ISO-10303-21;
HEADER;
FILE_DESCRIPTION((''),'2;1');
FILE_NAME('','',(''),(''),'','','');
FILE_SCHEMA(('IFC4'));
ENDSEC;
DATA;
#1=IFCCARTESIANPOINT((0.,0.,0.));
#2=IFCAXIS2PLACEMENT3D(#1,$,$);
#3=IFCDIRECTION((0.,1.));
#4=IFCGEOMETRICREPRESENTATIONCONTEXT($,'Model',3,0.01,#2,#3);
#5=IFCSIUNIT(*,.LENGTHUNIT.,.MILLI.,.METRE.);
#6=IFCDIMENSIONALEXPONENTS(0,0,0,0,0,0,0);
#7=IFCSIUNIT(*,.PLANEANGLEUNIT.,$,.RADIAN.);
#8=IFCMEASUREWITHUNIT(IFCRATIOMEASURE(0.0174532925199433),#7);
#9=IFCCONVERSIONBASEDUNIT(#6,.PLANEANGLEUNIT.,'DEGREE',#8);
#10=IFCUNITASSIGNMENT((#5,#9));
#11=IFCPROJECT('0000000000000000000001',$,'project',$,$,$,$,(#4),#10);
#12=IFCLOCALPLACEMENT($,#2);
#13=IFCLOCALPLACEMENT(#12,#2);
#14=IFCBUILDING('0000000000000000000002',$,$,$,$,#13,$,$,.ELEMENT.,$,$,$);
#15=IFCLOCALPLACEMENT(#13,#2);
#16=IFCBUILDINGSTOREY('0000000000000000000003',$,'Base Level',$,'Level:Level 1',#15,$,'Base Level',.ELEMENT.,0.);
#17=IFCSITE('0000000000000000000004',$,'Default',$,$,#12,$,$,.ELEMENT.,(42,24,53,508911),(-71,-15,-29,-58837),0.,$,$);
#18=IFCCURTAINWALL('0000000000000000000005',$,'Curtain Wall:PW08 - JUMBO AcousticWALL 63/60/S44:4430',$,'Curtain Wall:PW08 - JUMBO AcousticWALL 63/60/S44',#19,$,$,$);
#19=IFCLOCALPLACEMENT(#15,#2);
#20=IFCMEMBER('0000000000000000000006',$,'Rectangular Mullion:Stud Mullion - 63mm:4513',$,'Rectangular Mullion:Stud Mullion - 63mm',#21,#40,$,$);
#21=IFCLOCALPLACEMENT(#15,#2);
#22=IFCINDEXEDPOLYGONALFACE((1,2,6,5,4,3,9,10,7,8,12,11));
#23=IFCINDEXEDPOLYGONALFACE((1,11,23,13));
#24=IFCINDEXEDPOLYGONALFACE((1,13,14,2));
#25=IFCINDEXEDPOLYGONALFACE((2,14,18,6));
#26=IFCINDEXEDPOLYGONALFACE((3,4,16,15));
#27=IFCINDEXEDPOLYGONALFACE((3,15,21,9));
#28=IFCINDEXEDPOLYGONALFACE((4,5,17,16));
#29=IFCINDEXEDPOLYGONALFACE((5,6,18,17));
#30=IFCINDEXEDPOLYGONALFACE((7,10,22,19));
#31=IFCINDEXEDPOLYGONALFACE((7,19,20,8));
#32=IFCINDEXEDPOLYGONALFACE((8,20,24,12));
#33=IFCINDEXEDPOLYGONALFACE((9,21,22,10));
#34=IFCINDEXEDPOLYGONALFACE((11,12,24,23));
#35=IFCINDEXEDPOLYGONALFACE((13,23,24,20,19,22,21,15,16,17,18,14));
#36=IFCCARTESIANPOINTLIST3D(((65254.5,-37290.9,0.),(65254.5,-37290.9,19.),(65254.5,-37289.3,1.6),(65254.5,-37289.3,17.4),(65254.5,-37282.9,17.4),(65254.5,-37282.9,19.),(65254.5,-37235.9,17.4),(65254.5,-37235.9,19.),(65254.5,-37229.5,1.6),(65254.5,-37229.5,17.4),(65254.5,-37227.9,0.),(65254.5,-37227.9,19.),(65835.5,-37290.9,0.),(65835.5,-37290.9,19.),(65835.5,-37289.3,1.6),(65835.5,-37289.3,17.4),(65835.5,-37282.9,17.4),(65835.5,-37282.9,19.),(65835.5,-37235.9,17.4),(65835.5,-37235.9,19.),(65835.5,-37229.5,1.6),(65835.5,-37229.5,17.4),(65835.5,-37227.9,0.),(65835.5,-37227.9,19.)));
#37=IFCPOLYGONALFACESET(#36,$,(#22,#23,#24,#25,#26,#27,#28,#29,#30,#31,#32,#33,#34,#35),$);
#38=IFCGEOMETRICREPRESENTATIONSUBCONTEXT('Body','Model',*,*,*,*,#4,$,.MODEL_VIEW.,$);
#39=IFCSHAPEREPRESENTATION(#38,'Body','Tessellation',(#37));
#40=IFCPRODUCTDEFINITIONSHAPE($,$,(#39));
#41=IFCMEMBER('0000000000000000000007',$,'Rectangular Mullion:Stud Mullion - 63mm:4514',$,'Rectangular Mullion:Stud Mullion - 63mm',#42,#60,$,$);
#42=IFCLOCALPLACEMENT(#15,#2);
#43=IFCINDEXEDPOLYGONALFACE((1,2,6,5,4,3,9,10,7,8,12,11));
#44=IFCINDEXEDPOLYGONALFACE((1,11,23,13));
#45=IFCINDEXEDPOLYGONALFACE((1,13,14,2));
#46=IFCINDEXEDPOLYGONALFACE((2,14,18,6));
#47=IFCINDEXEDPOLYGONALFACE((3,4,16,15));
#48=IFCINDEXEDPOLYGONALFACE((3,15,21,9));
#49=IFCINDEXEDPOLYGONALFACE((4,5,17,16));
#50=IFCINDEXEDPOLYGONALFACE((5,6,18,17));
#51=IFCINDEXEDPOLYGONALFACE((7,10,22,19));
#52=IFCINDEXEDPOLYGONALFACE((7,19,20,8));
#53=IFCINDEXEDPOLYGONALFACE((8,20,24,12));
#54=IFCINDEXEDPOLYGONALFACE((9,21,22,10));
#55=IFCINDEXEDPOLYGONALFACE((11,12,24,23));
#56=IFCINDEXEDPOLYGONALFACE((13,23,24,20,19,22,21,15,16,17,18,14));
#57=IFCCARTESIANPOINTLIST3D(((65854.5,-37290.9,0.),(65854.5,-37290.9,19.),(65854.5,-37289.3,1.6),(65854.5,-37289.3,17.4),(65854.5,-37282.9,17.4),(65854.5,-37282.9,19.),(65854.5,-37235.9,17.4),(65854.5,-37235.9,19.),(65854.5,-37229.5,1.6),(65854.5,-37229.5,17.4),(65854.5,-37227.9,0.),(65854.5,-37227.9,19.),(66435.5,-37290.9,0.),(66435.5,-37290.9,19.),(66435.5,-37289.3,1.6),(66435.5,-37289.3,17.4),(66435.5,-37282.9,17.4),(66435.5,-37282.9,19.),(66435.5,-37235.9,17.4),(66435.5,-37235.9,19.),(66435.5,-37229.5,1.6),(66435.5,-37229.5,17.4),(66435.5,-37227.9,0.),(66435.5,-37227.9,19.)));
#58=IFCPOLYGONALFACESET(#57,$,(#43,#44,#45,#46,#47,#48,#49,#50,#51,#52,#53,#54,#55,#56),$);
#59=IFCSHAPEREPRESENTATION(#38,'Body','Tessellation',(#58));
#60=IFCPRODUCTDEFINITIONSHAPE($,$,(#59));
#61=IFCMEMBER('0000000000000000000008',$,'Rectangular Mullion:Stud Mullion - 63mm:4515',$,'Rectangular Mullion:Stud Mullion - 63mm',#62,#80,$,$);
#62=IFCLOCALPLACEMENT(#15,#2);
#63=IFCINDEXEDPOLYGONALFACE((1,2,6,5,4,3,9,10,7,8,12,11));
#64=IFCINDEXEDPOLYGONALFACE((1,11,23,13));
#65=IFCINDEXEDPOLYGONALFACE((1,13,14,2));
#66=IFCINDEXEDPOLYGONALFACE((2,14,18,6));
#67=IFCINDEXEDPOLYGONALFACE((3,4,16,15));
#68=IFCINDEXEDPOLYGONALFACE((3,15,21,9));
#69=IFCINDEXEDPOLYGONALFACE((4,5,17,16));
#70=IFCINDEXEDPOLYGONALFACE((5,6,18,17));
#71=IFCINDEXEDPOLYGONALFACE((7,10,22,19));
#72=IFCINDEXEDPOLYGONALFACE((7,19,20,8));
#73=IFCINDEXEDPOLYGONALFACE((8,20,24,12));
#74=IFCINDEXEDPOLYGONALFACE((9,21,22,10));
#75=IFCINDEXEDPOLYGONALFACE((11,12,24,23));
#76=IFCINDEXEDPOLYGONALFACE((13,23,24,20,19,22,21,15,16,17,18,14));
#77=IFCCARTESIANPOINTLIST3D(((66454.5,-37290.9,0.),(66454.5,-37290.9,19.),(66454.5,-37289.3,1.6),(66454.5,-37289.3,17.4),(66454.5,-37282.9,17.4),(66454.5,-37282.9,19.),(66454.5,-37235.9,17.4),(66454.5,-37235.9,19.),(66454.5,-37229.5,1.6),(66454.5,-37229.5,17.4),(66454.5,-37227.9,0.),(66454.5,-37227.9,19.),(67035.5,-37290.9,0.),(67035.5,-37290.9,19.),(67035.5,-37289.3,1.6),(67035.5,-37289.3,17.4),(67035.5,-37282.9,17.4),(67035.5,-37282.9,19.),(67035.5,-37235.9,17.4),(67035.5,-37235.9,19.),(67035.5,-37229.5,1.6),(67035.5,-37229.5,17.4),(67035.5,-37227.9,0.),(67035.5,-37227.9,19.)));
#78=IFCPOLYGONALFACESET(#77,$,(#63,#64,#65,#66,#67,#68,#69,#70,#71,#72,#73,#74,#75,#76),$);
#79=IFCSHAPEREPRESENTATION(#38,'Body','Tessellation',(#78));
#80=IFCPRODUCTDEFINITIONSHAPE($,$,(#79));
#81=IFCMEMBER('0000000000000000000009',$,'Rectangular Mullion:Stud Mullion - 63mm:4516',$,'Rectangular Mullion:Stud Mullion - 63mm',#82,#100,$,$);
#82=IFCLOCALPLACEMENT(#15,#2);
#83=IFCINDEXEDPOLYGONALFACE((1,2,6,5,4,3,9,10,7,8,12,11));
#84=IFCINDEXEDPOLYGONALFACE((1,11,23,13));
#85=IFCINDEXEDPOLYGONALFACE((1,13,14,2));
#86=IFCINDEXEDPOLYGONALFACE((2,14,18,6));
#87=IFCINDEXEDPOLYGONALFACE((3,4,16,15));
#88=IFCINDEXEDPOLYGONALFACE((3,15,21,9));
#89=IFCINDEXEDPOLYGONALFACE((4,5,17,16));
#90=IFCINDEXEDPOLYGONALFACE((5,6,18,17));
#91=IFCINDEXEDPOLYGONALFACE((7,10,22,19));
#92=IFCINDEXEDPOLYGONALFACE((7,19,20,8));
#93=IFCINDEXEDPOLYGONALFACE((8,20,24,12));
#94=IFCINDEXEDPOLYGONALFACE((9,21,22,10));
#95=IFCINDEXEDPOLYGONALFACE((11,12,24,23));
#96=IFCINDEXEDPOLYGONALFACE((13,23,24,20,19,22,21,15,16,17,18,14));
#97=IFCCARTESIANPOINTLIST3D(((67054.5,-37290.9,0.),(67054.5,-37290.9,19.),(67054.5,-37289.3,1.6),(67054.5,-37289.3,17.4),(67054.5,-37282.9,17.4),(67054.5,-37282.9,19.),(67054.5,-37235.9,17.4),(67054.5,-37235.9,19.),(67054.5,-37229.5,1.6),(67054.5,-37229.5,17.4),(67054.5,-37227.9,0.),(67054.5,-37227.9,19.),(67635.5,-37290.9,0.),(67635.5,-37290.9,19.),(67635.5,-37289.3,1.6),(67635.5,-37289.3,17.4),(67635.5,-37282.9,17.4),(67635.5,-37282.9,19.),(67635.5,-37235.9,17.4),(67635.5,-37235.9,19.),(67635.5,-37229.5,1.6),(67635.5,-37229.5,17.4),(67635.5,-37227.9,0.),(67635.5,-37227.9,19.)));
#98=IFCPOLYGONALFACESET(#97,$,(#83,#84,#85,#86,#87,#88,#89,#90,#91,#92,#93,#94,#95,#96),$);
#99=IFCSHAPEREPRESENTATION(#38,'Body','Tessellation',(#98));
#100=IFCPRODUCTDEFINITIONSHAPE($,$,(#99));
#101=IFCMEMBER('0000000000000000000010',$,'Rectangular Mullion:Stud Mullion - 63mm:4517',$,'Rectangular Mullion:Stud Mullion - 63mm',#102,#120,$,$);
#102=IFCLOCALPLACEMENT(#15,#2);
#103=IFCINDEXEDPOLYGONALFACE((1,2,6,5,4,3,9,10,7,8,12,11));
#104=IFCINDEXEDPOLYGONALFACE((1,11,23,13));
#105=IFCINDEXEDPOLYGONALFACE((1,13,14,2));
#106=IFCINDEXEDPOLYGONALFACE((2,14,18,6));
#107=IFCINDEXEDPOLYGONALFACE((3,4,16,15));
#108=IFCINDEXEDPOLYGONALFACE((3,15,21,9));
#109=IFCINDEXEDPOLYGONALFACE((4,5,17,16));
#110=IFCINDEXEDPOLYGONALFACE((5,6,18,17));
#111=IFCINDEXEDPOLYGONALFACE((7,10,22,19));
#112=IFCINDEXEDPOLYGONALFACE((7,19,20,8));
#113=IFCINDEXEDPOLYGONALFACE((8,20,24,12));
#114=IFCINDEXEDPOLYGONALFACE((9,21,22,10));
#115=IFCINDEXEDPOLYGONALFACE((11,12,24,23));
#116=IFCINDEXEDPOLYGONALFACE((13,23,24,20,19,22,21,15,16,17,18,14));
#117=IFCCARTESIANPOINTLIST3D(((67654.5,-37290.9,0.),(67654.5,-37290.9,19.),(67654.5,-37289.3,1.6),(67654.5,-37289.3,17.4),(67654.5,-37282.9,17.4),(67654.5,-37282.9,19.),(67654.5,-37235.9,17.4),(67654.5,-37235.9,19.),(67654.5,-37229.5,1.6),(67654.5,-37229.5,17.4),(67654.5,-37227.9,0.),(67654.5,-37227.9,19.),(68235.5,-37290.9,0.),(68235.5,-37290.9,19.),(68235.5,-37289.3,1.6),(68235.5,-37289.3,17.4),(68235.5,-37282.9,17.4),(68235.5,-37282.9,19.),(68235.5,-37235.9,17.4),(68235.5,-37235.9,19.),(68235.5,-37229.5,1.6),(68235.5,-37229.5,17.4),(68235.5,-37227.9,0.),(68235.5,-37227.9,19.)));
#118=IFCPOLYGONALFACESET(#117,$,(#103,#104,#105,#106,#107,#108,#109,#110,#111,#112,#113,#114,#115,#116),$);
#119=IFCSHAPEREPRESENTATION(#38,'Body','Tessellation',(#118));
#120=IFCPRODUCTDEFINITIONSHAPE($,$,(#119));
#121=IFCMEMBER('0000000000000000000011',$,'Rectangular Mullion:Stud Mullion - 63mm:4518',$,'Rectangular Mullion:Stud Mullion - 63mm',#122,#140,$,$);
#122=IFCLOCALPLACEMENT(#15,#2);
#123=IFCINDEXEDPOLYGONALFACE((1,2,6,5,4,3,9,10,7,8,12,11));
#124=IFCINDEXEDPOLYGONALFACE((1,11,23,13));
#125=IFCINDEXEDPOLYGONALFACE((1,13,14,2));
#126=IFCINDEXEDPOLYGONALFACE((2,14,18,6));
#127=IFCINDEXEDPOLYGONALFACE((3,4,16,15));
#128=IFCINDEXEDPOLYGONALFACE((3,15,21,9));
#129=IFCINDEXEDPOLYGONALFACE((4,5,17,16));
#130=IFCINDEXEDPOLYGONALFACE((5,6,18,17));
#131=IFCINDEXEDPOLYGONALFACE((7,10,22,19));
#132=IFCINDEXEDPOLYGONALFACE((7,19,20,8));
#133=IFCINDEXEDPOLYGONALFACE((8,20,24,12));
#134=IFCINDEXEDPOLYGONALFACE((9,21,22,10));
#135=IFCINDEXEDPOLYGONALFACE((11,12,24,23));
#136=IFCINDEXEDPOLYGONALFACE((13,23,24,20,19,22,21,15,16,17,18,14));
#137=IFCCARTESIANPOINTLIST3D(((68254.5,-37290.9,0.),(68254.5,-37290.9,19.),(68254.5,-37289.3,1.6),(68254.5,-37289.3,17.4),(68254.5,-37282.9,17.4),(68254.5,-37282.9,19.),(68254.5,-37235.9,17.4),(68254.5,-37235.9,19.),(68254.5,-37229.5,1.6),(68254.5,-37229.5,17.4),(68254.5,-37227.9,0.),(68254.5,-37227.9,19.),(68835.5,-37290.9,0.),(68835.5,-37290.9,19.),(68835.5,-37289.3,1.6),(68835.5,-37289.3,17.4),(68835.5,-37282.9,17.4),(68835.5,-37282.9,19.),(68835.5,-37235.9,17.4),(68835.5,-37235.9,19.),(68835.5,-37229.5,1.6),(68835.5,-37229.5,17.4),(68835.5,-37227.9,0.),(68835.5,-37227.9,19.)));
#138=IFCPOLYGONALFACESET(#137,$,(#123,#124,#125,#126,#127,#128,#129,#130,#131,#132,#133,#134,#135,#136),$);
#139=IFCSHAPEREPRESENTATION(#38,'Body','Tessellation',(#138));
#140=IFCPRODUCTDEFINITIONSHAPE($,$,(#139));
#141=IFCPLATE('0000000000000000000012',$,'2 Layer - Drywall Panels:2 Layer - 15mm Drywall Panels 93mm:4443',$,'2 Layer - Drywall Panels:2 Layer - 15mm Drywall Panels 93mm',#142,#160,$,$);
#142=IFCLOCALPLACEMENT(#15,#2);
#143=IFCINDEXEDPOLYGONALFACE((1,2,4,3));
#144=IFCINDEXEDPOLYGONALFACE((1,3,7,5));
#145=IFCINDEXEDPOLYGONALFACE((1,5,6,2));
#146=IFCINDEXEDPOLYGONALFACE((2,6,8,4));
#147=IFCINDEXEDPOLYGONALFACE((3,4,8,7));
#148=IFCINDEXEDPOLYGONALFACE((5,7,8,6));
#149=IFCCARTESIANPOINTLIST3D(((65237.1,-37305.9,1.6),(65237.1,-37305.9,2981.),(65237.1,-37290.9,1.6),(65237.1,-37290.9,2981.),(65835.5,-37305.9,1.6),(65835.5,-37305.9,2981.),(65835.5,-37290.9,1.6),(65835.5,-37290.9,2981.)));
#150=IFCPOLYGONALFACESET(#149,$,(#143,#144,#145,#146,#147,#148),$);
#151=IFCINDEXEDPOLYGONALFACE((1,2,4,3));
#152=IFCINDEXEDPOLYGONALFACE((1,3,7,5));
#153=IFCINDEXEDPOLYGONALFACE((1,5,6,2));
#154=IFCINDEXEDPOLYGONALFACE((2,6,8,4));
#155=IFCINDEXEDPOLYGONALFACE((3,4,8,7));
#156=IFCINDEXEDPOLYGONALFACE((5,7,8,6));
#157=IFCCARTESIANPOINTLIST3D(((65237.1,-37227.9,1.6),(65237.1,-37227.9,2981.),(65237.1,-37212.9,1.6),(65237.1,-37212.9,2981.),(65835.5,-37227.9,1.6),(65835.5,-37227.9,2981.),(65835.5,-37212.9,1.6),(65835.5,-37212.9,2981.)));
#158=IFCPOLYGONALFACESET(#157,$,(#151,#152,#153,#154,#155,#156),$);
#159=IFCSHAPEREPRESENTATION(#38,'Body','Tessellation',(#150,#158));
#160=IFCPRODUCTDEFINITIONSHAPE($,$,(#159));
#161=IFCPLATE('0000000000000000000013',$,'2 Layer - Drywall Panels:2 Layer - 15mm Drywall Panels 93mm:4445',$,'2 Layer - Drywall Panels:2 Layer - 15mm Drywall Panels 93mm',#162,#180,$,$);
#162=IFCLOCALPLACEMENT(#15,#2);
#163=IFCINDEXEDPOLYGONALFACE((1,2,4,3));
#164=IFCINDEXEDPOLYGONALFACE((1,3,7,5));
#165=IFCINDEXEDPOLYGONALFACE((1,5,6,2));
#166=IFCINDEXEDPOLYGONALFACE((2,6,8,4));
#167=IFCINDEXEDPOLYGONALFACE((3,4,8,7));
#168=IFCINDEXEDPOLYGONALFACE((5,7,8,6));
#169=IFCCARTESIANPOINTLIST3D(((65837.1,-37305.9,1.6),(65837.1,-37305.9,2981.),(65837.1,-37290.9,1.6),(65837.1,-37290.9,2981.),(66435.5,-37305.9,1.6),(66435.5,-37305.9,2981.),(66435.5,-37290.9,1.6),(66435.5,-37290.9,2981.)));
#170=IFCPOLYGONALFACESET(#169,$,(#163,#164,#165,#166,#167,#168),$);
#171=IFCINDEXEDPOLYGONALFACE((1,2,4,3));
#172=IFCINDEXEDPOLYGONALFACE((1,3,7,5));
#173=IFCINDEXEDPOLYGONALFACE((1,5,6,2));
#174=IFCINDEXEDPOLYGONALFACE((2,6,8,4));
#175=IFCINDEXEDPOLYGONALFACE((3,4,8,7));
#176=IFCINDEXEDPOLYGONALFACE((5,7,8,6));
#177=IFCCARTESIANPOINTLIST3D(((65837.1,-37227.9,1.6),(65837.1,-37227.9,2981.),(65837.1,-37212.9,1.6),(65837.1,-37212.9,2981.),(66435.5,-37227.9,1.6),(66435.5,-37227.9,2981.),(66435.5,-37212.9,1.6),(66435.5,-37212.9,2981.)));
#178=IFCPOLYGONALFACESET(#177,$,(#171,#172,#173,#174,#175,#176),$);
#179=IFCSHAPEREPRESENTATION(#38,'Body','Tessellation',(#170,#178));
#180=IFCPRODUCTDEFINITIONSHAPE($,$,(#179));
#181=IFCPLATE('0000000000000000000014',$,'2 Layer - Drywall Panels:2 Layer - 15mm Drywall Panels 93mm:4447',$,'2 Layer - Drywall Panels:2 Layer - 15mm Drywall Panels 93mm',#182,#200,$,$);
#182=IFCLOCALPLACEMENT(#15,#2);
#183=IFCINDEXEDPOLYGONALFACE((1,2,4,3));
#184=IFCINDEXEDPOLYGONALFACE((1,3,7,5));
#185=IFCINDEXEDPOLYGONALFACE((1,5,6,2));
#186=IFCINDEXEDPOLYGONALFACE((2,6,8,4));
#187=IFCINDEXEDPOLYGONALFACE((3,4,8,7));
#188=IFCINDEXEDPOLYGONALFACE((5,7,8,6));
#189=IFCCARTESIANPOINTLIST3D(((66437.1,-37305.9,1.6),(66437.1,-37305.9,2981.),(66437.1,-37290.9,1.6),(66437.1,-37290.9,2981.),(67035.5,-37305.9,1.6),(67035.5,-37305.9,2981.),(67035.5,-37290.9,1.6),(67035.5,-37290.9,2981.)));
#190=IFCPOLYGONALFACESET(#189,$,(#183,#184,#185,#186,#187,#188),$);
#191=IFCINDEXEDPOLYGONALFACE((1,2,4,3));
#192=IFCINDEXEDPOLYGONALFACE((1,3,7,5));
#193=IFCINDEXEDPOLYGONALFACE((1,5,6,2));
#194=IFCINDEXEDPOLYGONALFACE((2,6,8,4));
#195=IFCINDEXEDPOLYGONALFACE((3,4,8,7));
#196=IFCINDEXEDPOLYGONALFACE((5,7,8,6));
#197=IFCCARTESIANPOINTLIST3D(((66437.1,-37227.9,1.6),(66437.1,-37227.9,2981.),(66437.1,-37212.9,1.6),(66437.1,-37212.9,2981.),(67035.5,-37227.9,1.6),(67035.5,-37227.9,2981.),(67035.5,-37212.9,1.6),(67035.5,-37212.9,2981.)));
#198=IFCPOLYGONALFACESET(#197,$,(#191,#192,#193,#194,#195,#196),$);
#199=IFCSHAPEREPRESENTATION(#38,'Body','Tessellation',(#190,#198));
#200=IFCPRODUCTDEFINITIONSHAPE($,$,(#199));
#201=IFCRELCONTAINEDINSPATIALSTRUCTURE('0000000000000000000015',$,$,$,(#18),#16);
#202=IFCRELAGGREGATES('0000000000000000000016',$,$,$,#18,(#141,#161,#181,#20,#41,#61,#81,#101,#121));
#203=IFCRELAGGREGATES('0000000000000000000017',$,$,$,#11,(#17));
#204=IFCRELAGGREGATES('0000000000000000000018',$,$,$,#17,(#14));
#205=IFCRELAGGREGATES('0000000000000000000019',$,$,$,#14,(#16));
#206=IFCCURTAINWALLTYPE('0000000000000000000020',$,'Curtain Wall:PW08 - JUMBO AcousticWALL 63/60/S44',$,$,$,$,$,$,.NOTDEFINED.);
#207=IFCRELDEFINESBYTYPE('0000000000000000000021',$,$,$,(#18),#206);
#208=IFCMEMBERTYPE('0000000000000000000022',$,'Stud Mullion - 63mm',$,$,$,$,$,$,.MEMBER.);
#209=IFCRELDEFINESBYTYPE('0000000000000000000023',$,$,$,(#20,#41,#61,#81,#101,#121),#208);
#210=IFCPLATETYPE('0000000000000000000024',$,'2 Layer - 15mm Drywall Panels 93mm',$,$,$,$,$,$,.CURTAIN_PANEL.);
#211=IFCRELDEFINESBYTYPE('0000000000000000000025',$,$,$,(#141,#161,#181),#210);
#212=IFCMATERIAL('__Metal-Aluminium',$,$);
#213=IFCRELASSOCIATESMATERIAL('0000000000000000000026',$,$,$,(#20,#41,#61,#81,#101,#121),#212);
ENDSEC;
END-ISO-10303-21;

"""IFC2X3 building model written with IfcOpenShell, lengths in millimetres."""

from ifc_helpers import new_model, entity, si_unit, converted_unit, direction, frame, frame_2d, origin, place, context, subcontext, project, spatial, polyline, rectangle, outline, extrude, source, transform, mapped, material, type_object, type_shapes, element, aggregate, save


model = new_model("IFC2X3")

# Units and contexts
model_context = context("Model", 3, precision=0.01, world=origin(), true_north=direction((0.0, 1.0)))
body_context = subcontext(model_context, "Body", "Model", "MODEL_VIEW")
ifc_project = project(units=[si_unit("LENGTHUNIT", "METRE", prefix="MILLI"), converted_unit("PLANEANGLEUNIT", "DEGREE", entity("IfcRatioMeasure", 0.0174532925199433), si_unit("PLANEANGLEUNIT", "RADIAN"), dimensions=[0, 0, 0, 0, 0, 0, 0])], contexts=[model_context])

# Site, building, storey
site_placement = place(None, origin())
site = spatial("IfcSite", under=ifc_project, at=site_placement, Name="Default", CompositionType="ELEMENT", RefLatitude=(42, 24, 53, 508911), RefLongitude=(-71, -15, -29, -58837), RefElevation=0.0)
building_placement = place(site_placement, origin())
building = spatial("IfcBuilding", under=site, at=building_placement, CompositionType="ELEMENT")
storey_placement = place(building_placement, origin())
storey = spatial("IfcBuildingStorey", under=building, at=storey_placement, Name="Base Level", ObjectType="Level:Level 1", LongName="Base Level", CompositionType="ELEMENT", Elevation=0.0)

# Curtain wall, members, plates
curtain_wall_type = type_object("IfcCurtainWallType", Name="Curtain Wall:PW08 - JUMBO AcousticWALL 63/60/S44", PredefinedType="NOTDEFINED")
curtain_wall_placement = place(building_placement, origin())
curtain_wall = element("IfcCurtainWall", 1, at=curtain_wall_placement, inside=storey, type_object=curtain_wall_type, Name="Curtain Wall:PW08 - JUMBO AcousticWALL 63/60/S44:4430", ObjectType="Curtain Wall:PW08 - JUMBO AcousticWALL 63/60/S44")
ifc_material = material(Name="__Metal-Aluminium")
member_type_1 = type_object("IfcMemberType", Name="Stud Mullion - 63mm", PredefinedType="MEMBER")
shared_shape_1 = source(origin(), body_context, "Body", "SweptSolid", [
    extrude(outline(polyline([(23.5, -6.6), (31.5, -6.6), (31.5, 12.4), (-31.5, 12.4), (-31.5, -6.6), (-23.5, -6.6), (-23.5, -5.0), (-29.9, -5.0), (-29.9, 10.8), (29.9, 10.8), (29.9, -5.0), (23.5, -5.0), (23.5, -6.6)])), frame((-12.4, 0.0, -581.0), z_axis=(0.0, 0.0, 1.0), x_axis=(0.0, -1.0, 0.0)), (0.0, 0.0, 1.0), 581.0),
])
type_shapes(member_type_1, [shared_shape_1])
member_1_placement = place(building_placement, frame((65254.5, -37259.4, 0.0), z_axis=(-1.0, 0.0, 0.0), x_axis=(0.0, 0.0, -1.0)))
member_1 = element("IfcMember", 2, at=member_1_placement, type_object=member_type_1, material=ifc_material, Name="Rectangular Mullion:Stud Mullion - 63mm:4513", ObjectType="Rectangular Mullion:Stud Mullion - 63mm", context=body_context, shape_type="MappedRepresentation", body=[
    mapped(shared_shape_1, transform((0.0, 0.0, 0.0), scale=1.0)),
])
member_2_placement = place(building_placement, frame((65854.5, -37259.4, 0.0), z_axis=(-1.0, 0.0, 0.0), x_axis=(0.0, 0.0, -1.0)))
member_2 = element("IfcMember", 3, at=member_2_placement, type_object=member_type_1, material=ifc_material, Name="Rectangular Mullion:Stud Mullion - 63mm:4514", ObjectType="Rectangular Mullion:Stud Mullion - 63mm", context=body_context, shape_type="MappedRepresentation", body=[
    mapped(shared_shape_1, transform((0.0, 0.0, 0.0), scale=1.0)),
])
member_3_placement = place(building_placement, frame((66454.5, -37259.4, 0.0), z_axis=(-1.0, 0.0, 0.0), x_axis=(0.0, 0.0, -1.0)))
member_3 = element("IfcMember", 4, at=member_3_placement, type_object=member_type_1, material=ifc_material, Name="Rectangular Mullion:Stud Mullion - 63mm:4515", ObjectType="Rectangular Mullion:Stud Mullion - 63mm", context=body_context, shape_type="MappedRepresentation", body=[
    mapped(shared_shape_1, transform((0.0, 0.0, 0.0), scale=1.0)),
])
member_4_placement = place(building_placement, frame((67054.5, -37259.4, 0.0), z_axis=(-1.0, 0.0, 0.0), x_axis=(0.0, 0.0, -1.0)))
member_4 = element("IfcMember", 5, at=member_4_placement, type_object=member_type_1, material=ifc_material, Name="Rectangular Mullion:Stud Mullion - 63mm:4516", ObjectType="Rectangular Mullion:Stud Mullion - 63mm", context=body_context, shape_type="MappedRepresentation", body=[
    mapped(shared_shape_1, transform((0.0, 0.0, 0.0), scale=1.0)),
])
member_5_placement = place(building_placement, frame((67654.5, -37259.4, 0.0), z_axis=(-1.0, 0.0, 0.0), x_axis=(0.0, 0.0, -1.0)))
member_5 = element("IfcMember", 6, at=member_5_placement, type_object=member_type_1, material=ifc_material, Name="Rectangular Mullion:Stud Mullion - 63mm:4517", ObjectType="Rectangular Mullion:Stud Mullion - 63mm", context=body_context, shape_type="MappedRepresentation", body=[
    mapped(shared_shape_1, transform((0.0, 0.0, 0.0), scale=1.0)),
])
member_6_placement = place(building_placement, frame((68254.5, -37259.4, 0.0), z_axis=(-1.0, 0.0, 0.0), x_axis=(0.0, 0.0, -1.0)))
member_6 = element("IfcMember", 7, at=member_6_placement, type_object=member_type_1, material=ifc_material, Name="Rectangular Mullion:Stud Mullion - 63mm:4518", ObjectType="Rectangular Mullion:Stud Mullion - 63mm", context=body_context, shape_type="MappedRepresentation", body=[
    mapped(shared_shape_1, transform((0.0, 0.0, 0.0), scale=1.0)),
])
plate_type = type_object("IfcPlateType", Name="2 Layer - 15mm Drywall Panels 93mm", PredefinedType="CURTAIN_PANEL")
shared_shape_2 = source(origin(), body_context, "Body", "SweptSolid", [
    extrude(rectangle(XDim=598.4, YDim=15.0, at=frame_2d((0.0, 0.0), x_axis=(1.0, 0.0))), frame((0.0, -39.0, 0.0), z_axis=(0.0, 0.0, 1.0), x_axis=(-1.0, 0.0, 0.0)), (0.0, 0.0, 1.0), 2979.4),
    extrude(rectangle(XDim=15.0, YDim=598.4, at=frame_2d((0.0, 0.0), x_axis=(1.0, 0.0))), frame((0.0, 39.0, 0.0), z_axis=(0.0, 0.0, 1.0), x_axis=(0.0, 1.0, 0.0)), (0.0, 0.0, 1.0), 2979.4),
])
type_shapes(plate_type, [shared_shape_2])
plate_1_placement = place(curtain_wall_placement, frame((65536.3, -37259.4, 1.6)))
plate_1 = element("IfcPlate", 8, at=plate_1_placement, type_object=plate_type, Name="2 Layer - Drywall Panels:2 Layer - 15mm Drywall Panels 93mm:4443", ObjectType="2 Layer - Drywall Panels:2 Layer - 15mm Drywall Panels 93mm", context=body_context, shape_type="MappedRepresentation", body=[
    mapped(shared_shape_2, transform((0.0, 0.0, 0.0), scale=1.0)),
])
plate_2_placement = place(curtain_wall_placement, frame((66136.3, -37259.4, 1.6)))
plate_2 = element("IfcPlate", 9, at=plate_2_placement, type_object=plate_type, Name="2 Layer - Drywall Panels:2 Layer - 15mm Drywall Panels 93mm:4445", ObjectType="2 Layer - Drywall Panels:2 Layer - 15mm Drywall Panels 93mm", context=body_context, shape_type="MappedRepresentation", body=[
    mapped(shared_shape_2, transform((0.0, 0.0, 0.0), scale=1.0)),
])
plate_3_placement = place(curtain_wall_placement, frame((66736.3, -37259.4, 1.6)))
plate_3 = element("IfcPlate", 10, at=plate_3_placement, type_object=plate_type, Name="2 Layer - Drywall Panels:2 Layer - 15mm Drywall Panels 93mm:4447", ObjectType="2 Layer - Drywall Panels:2 Layer - 15mm Drywall Panels 93mm", context=body_context, shape_type="MappedRepresentation", body=[
    mapped(shared_shape_2, transform((0.0, 0.0, 0.0), scale=1.0)),
])
aggregate(curtain_wall, [plate_1, plate_2, plate_3, member_1, member_2, member_3, member_4, member_5, member_6])

save(model, "model.ifc")
